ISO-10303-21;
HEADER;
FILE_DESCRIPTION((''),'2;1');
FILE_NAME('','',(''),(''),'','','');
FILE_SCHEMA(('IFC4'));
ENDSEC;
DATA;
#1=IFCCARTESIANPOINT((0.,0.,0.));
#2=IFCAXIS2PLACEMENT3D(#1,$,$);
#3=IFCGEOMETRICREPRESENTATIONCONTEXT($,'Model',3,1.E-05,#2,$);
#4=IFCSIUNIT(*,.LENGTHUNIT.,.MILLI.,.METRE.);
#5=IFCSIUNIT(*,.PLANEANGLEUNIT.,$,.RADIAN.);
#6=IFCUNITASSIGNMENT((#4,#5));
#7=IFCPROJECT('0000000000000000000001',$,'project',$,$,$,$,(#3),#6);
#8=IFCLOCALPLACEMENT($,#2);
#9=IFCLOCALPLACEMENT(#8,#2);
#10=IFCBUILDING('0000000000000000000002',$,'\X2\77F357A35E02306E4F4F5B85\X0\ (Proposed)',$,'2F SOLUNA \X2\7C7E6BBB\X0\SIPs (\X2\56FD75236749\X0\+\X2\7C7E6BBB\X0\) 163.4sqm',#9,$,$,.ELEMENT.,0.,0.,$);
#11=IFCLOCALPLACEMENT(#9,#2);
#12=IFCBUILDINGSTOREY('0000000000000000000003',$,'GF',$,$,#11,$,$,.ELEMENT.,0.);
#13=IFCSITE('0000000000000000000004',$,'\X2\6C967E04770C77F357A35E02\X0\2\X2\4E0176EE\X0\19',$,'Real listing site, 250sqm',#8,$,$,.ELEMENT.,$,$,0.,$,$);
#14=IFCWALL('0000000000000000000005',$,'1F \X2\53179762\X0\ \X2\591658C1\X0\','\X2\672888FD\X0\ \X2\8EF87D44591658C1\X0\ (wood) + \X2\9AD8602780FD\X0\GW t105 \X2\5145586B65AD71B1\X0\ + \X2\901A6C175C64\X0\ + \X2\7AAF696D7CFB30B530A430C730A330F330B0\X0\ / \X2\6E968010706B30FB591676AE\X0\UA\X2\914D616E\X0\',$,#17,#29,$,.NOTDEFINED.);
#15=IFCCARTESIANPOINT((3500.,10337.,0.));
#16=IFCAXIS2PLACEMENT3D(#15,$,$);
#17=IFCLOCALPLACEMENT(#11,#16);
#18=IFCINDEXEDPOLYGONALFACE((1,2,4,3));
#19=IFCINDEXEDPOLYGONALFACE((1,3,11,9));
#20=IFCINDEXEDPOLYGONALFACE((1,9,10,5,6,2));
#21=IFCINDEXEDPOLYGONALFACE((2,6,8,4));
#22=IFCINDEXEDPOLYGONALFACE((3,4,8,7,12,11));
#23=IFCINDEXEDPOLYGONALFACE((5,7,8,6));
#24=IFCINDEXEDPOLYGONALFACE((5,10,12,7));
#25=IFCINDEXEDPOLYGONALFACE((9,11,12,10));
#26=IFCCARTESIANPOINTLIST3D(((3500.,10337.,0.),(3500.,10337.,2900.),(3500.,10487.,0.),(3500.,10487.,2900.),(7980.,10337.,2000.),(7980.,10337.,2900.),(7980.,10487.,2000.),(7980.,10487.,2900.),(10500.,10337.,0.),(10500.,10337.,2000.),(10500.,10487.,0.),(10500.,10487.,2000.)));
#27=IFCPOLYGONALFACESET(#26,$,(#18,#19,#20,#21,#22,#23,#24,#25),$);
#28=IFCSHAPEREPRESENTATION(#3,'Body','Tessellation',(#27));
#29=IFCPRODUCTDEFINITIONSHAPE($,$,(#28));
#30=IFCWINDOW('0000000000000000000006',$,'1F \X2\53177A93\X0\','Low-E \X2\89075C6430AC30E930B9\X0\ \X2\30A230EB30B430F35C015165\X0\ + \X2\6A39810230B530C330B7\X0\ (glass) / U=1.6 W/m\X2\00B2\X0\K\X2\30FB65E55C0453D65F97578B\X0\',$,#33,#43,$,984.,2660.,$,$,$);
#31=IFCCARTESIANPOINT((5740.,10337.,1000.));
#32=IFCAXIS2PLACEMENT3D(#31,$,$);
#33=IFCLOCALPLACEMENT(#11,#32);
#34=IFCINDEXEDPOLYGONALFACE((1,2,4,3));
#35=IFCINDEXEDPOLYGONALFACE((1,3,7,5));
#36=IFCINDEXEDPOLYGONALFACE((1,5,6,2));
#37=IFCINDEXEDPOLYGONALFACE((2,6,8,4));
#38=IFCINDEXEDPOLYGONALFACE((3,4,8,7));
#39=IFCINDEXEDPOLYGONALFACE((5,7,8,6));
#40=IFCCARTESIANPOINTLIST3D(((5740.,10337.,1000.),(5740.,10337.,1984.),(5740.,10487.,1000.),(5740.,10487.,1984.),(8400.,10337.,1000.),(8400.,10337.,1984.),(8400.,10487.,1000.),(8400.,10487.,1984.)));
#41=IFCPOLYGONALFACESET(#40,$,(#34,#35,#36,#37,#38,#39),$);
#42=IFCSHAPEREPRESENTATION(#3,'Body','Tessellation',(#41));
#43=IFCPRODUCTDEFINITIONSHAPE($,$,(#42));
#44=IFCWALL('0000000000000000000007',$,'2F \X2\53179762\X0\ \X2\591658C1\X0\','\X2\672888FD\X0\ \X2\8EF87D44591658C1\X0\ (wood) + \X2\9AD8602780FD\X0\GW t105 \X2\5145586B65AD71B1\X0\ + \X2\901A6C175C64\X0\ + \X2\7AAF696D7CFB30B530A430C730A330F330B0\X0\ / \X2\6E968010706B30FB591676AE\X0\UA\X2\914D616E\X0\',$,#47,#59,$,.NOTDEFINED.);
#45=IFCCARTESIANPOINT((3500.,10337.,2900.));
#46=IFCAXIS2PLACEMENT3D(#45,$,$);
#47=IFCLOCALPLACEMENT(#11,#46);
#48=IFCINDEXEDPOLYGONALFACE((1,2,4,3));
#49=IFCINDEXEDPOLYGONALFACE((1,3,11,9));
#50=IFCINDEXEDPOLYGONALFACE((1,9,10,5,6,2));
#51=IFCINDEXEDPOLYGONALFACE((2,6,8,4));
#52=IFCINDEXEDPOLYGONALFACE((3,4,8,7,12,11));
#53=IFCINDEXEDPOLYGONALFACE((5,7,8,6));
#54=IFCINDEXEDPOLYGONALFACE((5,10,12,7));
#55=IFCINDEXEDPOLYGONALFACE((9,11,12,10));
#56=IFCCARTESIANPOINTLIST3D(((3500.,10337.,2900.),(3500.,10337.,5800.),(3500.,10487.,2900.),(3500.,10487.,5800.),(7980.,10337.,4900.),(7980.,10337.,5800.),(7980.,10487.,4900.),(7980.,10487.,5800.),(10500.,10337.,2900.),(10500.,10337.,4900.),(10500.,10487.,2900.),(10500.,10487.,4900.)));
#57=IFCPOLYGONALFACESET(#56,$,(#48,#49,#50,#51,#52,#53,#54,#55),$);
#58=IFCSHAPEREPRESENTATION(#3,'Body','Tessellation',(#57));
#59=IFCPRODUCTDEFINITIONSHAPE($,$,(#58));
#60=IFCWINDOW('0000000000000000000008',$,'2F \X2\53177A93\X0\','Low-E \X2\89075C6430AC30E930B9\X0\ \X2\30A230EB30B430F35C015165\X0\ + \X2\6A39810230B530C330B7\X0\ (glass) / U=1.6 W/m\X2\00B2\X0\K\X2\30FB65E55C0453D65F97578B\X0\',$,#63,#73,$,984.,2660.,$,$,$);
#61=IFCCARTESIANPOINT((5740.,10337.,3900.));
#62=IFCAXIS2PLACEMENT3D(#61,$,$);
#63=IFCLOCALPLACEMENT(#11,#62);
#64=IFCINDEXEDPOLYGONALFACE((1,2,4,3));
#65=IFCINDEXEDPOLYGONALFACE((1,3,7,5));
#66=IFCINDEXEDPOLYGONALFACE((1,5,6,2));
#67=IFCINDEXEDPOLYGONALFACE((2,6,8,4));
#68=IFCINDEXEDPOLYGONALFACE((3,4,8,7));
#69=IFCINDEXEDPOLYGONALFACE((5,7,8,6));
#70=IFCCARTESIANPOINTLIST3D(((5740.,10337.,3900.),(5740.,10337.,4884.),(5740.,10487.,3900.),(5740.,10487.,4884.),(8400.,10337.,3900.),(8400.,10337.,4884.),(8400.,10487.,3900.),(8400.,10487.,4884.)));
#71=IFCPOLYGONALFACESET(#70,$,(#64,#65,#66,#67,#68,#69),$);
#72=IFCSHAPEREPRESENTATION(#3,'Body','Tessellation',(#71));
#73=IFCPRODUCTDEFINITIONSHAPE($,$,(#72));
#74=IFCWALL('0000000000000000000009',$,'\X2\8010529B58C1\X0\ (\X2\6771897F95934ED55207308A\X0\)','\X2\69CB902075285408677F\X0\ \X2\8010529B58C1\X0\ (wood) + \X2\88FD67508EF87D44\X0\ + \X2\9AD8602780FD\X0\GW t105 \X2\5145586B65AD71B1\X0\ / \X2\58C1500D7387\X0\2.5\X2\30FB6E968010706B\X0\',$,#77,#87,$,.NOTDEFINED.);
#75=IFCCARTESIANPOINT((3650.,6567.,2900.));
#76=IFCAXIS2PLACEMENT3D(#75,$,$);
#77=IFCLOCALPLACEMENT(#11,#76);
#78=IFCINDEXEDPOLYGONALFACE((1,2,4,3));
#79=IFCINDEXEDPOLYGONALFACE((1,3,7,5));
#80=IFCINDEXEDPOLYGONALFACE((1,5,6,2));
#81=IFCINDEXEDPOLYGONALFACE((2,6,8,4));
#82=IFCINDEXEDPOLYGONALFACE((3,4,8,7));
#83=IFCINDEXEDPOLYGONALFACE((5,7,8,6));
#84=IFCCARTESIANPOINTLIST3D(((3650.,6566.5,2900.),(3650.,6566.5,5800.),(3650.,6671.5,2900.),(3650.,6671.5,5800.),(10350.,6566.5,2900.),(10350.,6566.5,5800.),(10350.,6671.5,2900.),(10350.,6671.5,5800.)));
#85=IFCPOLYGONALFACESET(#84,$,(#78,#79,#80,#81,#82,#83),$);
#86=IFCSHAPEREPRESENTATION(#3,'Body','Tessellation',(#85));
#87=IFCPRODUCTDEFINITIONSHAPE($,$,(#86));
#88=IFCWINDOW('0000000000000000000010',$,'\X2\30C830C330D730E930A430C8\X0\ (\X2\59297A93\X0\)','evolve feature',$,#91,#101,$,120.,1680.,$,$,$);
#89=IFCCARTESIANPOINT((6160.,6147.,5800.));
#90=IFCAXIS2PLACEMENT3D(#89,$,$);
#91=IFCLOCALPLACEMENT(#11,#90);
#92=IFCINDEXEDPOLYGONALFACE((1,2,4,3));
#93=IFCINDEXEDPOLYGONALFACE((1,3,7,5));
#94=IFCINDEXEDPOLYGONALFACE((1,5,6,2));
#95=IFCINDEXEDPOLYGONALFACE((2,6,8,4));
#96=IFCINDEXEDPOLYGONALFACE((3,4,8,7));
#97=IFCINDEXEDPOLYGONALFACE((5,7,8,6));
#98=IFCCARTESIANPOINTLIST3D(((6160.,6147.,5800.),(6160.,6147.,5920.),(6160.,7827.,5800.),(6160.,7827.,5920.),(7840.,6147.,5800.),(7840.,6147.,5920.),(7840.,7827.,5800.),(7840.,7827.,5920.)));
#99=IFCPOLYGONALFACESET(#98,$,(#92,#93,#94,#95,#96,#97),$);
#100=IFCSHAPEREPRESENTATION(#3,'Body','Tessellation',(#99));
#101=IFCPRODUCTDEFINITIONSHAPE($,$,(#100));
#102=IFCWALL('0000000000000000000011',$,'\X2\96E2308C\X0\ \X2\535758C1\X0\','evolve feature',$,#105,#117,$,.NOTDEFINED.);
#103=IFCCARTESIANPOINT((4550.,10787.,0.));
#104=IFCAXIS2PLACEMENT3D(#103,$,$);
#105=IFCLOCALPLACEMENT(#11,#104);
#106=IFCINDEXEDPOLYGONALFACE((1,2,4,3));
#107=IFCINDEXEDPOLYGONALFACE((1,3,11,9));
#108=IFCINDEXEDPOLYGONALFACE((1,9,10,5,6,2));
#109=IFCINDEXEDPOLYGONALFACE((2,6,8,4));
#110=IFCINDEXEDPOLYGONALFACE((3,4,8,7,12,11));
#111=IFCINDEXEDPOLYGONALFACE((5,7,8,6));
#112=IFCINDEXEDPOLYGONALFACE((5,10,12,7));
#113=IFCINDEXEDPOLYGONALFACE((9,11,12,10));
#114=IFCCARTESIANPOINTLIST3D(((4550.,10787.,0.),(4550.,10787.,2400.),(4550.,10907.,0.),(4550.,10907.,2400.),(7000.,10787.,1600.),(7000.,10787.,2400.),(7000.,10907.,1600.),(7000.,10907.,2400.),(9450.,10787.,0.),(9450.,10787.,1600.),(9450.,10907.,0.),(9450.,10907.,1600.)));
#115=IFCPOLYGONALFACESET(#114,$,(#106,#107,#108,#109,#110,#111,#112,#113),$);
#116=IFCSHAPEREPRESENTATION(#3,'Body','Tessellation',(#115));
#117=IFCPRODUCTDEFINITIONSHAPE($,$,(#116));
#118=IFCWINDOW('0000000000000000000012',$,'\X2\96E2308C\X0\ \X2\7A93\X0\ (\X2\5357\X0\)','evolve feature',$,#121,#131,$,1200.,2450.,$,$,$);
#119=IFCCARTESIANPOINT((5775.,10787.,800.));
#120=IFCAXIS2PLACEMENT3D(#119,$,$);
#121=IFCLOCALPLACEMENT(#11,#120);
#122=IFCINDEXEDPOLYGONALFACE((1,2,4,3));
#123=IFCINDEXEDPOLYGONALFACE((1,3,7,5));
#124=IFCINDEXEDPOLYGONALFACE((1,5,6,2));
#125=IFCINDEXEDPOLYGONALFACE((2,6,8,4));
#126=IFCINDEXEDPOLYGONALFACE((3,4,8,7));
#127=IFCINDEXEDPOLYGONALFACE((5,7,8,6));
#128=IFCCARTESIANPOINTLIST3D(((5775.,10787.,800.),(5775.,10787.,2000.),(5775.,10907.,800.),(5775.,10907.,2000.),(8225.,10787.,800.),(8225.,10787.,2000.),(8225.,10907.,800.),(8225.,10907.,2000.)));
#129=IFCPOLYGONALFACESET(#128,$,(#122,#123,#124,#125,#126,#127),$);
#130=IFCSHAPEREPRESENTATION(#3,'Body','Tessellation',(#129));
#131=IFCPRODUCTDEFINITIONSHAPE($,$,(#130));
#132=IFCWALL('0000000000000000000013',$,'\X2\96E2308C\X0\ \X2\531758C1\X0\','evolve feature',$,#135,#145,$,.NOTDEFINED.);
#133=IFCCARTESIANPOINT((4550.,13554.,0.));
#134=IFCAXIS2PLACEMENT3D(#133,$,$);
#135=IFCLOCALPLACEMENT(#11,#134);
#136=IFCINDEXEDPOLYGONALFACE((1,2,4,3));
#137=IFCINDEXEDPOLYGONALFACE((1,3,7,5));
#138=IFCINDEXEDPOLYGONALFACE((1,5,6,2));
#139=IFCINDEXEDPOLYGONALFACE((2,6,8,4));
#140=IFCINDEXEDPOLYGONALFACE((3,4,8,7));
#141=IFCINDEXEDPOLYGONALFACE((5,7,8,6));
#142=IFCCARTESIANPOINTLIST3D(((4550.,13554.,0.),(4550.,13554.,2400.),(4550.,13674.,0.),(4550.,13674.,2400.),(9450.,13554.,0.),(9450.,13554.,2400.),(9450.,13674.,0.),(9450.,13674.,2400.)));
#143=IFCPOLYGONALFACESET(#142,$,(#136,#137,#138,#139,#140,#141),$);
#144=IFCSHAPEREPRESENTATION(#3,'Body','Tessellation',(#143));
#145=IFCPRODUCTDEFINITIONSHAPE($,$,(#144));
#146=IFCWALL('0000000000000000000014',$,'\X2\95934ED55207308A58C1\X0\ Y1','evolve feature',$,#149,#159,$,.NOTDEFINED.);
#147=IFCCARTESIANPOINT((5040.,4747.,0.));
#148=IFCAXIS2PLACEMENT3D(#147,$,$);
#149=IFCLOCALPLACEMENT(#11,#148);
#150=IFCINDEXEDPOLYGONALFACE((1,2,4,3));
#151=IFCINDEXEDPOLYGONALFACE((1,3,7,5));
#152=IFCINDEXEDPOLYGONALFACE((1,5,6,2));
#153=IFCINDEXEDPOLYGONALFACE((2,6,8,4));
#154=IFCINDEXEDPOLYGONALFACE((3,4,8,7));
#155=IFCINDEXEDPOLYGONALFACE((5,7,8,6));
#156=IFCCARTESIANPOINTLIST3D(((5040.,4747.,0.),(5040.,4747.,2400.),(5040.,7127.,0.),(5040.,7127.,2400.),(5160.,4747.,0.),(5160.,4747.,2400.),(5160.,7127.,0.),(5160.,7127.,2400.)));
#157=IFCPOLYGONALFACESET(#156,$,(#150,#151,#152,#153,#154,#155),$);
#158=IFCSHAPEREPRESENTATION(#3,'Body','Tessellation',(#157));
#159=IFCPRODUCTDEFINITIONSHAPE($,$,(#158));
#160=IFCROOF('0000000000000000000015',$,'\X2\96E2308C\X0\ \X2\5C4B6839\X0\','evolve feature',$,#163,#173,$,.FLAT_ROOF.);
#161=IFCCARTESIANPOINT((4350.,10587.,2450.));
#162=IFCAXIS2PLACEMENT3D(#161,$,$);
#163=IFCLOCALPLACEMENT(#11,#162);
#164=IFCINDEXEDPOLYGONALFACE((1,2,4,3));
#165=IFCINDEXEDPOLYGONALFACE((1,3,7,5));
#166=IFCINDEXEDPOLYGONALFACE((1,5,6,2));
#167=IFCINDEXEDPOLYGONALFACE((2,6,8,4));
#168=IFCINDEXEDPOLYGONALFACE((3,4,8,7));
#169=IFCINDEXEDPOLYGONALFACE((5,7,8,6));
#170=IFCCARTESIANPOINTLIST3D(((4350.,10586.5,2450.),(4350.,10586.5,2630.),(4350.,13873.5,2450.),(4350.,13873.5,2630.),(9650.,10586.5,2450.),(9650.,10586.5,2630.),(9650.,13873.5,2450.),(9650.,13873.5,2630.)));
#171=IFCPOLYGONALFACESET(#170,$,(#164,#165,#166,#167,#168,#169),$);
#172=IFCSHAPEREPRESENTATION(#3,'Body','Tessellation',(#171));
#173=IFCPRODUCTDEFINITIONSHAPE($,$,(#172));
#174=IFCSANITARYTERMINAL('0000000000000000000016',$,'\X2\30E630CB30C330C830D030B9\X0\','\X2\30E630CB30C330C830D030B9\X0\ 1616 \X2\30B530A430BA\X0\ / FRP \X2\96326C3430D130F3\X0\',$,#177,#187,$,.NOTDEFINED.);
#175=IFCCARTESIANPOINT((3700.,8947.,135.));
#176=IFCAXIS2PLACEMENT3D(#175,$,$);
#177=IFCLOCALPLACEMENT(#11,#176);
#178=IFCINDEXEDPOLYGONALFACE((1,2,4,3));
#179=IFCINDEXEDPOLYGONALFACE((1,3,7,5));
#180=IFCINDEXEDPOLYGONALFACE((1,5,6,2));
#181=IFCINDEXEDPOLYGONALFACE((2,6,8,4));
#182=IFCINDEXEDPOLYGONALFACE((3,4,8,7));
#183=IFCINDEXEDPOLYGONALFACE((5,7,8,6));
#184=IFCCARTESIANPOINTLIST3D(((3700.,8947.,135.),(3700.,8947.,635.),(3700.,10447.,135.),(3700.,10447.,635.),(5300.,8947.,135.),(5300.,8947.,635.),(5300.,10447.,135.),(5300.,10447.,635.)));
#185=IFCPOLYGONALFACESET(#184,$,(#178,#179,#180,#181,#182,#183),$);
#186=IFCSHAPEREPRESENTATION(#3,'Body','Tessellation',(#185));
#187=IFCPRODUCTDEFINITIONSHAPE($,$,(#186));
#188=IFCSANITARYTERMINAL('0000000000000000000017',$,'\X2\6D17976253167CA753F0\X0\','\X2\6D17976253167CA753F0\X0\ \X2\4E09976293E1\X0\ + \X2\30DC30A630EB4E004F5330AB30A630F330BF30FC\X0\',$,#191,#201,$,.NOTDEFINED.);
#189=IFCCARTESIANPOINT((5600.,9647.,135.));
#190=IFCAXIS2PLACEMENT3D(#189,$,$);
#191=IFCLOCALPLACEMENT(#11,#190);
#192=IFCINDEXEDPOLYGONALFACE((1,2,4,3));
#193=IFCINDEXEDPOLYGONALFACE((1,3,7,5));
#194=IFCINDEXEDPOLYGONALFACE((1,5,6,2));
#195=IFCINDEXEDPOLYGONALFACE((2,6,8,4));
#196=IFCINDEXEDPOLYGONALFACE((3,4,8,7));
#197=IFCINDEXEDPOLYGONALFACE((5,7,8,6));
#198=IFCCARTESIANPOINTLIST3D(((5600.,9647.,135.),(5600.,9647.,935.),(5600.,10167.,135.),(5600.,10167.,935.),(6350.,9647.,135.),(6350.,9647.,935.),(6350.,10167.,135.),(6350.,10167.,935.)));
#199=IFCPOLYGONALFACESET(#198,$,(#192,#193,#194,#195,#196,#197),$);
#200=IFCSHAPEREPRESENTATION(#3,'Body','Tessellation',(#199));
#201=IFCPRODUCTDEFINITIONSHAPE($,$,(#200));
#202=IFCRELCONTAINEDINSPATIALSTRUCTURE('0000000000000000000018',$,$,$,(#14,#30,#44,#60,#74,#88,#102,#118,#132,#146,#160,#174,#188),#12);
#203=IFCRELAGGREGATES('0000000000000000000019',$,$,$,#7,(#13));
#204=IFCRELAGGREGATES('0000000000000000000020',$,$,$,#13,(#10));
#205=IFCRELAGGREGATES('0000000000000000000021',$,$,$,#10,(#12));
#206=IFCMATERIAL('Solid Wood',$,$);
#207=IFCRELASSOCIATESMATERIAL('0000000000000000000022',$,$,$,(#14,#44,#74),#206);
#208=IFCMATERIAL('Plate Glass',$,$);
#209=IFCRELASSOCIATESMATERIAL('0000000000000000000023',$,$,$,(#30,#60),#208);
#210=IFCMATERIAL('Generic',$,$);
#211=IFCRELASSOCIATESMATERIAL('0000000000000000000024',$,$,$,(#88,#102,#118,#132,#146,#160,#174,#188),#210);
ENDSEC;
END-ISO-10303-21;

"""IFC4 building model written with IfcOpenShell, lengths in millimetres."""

from ifc_helpers import new_model, si_unit, frame, frame_2d, origin, place, context, project, spatial, rectangle, extrude, material, element, fill, save


model = new_model("IFC4")

# Units and contexts
model_context = context("Model", 3, precision=1e-05, world=origin())
ifc_project = project(units=[si_unit("LENGTHUNIT", "METRE", prefix="MILLI"), si_unit("PLANEANGLEUNIT", "RADIAN")], contexts=[model_context])

# Site, building, storey
site_placement = place(None, origin())
site = spatial("IfcSite", under=ifc_project, at=site_placement, Name="沖縄県石垣市2丁目19", ObjectType="Real listing site, 250sqm", CompositionType="ELEMENT", RefElevation=0.0)
building_placement = place(site_placement, origin())
building = spatial("IfcBuilding", under=site, at=building_placement, Name="石垣市の住宅 (Proposed)", ObjectType="2F SOLUNA 籾殻SIPs (国産杉+籾殻) 163.4sqm", CompositionType="ELEMENT", ElevationOfRefHeight=0.0, ElevationOfTerrain=0.0)
storey_placement = place(building_placement, origin())
storey = spatial("IfcBuildingStorey", under=building, at=storey_placement, Name="GF", CompositionType="ELEMENT", Elevation=0.0)

# Shared definitions
ifc_material_1 = material(Name="Generic")

# Wall, opening, window
ifc_material_2 = material(Name="Solid Wood")
wall_1_placement = place(storey_placement, frame((3500.0, 10337.0, 0.0)))
wall_1 = element("IfcWall", 1, at=wall_1_placement, inside=storey, material=ifc_material_2, Name="1F 北面 外壁", Description="木製 軸組外壁 (wood) + 高性能GW t105 充填断熱 + 通気層 + 窯業系サイディング / 準耐火・外皮UA配慮", PredefinedType="NOTDEFINED", context=model_context, shape_type="SweptSolid", body=[
    extrude(rectangle(XDim=7000.0, YDim=150.0, at=frame_2d((3500.0, 75.0))), frame((3500.0, 10337.0, 0.0)), (0.0, 0.0, 1.0), 2900.0),
])
opening_1_placement = place(storey_placement, frame((5740.0, 10337.0, 1000.0)))
opening_1 = element("IfcOpeningElement", 2, at=opening_1_placement, cuts=wall_1, PredefinedType="NOTDEFINED", context=model_context, shape_type="SweptSolid", body=[
    extrude(rectangle(XDim=2660.0, YDim=150.0, at=frame_2d((1330.0, 75.0))), frame((5740.0, 10337.0, 1000.0)), (0.0, 0.0, 1.0), 984.0),
])
ifc_material_3 = material(Name="Plate Glass")
window_1_placement = place(storey_placement, frame((5740.0, 10337.0, 1000.0)))
window_1 = element("IfcWindow", 3, at=window_1_placement, inside=storey, material=ifc_material_3, Name="1F 北窓", Description="Low-E 複層ガラス アルゴン封入 + 樹脂サッシ (glass) / U=1.6 W/m²K・日射取得型", OverallHeight=984.0, OverallWidth=2660.0, context=model_context, shape_type="SweptSolid", body=[
    extrude(rectangle(XDim=2660.0, YDim=150.0, at=frame_2d((1330.0, 75.0))), frame((5740.0, 10337.0, 1000.0)), (0.0, 0.0, 1.0), 984.0),
])
fill(opening_1, window_1)

# Wall, opening, window
wall_2_placement = place(storey_placement, frame((3500.0, 10337.0, 2900.0)))
wall_2 = element("IfcWall", 4, at=wall_2_placement, inside=storey, material=ifc_material_2, Name="2F 北面 外壁", Description="木製 軸組外壁 (wood) + 高性能GW t105 充填断熱 + 通気層 + 窯業系サイディング / 準耐火・外皮UA配慮", PredefinedType="NOTDEFINED", context=model_context, shape_type="SweptSolid", body=[
    extrude(rectangle(XDim=7000.0, YDim=150.0, at=frame_2d((3500.0, 75.0))), frame((3500.0, 10337.0, 2900.0)), (0.0, 0.0, 1.0), 2900.0),
])
opening_2_placement = place(storey_placement, frame((5740.0, 10337.0, 3900.0)))
opening_2 = element("IfcOpeningElement", 5, at=opening_2_placement, cuts=wall_2, PredefinedType="NOTDEFINED", context=model_context, shape_type="SweptSolid", body=[
    extrude(rectangle(XDim=2660.0, YDim=150.0, at=frame_2d((1330.0, 75.0))), frame((5740.0, 10337.0, 3900.0)), (0.0, 0.0, 1.0), 984.0),
])
window_2_placement = place(storey_placement, frame((5740.0, 10337.0, 3900.0)))
window_2 = element("IfcWindow", 6, at=window_2_placement, inside=storey, material=ifc_material_3, Name="2F 北窓", Description="Low-E 複層ガラス アルゴン封入 + 樹脂サッシ (glass) / U=1.6 W/m²K・日射取得型", OverallHeight=984.0, OverallWidth=2660.0, context=model_context, shape_type="SweptSolid", body=[
    extrude(rectangle(XDim=2660.0, YDim=150.0, at=frame_2d((1330.0, 75.0))), frame((5740.0, 10337.0, 3900.0)), (0.0, 0.0, 1.0), 984.0),
])
fill(opening_2, window_2)

# Wall
wall_3_placement = place(storey_placement, frame((3650.0, 6567.0, 2900.0)))
element("IfcWall", 7, at=wall_3_placement, inside=storey, material=ifc_material_2, Name="耐力壁 (東西間仕切り)", Description="構造用合板 耐力壁 (wood) + 製材軸組 + 高性能GW t105 充填断熱 / 壁倍率2.5・準耐火", PredefinedType="NOTDEFINED", context=model_context, shape_type="SweptSolid", body=[
    extrude(rectangle(XDim=6700.0, YDim=105.0, at=frame_2d((3350.0, 52.0))), frame((3650.0, 6567.0, 2900.0)), (0.0, 0.0, 1.0), 2900.0),
])

# Window
window_3_placement = place(storey_placement, frame((6160.0, 6147.0, 5800.0)))
element("IfcWindow", 8, at=window_3_placement, inside=storey, material=ifc_material_1, Name="トップライト (天窓)", Description="evolve feature", OverallHeight=120.0, OverallWidth=1680.0, context=model_context, shape_type="SweptSolid", body=[
    extrude(rectangle(XDim=1680.0, YDim=1680.0, at=frame_2d((840.0, 840.0))), frame((6160.0, 6147.0, 5800.0)), (0.0, 0.0, 1.0), 120.0),
])

# Wall, opening, window
wall_4_placement = place(storey_placement, frame((4550.0, 10787.0, 0.0)))
wall_4 = element("IfcWall", 9, at=wall_4_placement, inside=storey, material=ifc_material_1, Name="離れ 南壁", Description="evolve feature", PredefinedType="NOTDEFINED", context=model_context, shape_type="SweptSolid", body=[
    extrude(rectangle(XDim=4900.0, YDim=120.0, at=frame_2d((2450.0, 60.0))), frame((4550.0, 10787.0, 0.0)), (0.0, 0.0, 1.0), 2400.0),
])
opening_3_placement = place(storey_placement, frame((5775.0, 10787.0, 800.0)))
opening_3 = element("IfcOpeningElement", 10, at=opening_3_placement, cuts=wall_4, PredefinedType="NOTDEFINED", context=model_context, shape_type="SweptSolid", body=[
    extrude(rectangle(XDim=2450.0, YDim=120.0, at=frame_2d((1225.0, 60.0))), frame((5775.0, 10787.0, 800.0)), (0.0, 0.0, 1.0), 1200.0),
])
window_4_placement = place(storey_placement, frame((5775.0, 10787.0, 800.0)))
window_4 = element("IfcWindow", 11, at=window_4_placement, inside=storey, material=ifc_material_1, Name="離れ 窓 (南)", Description="evolve feature", OverallHeight=1200.0, OverallWidth=2450.0, context=model_context, shape_type="SweptSolid", body=[
    extrude(rectangle(XDim=2450.0, YDim=120.0, at=frame_2d((1225.0, 60.0))), frame((5775.0, 10787.0, 800.0)), (0.0, 0.0, 1.0), 1200.0),
])
fill(opening_3, window_4)

# Walls
wall_5_placement = place(storey_placement, frame((4550.0, 13554.0, 0.0)))
element("IfcWall", 12, at=wall_5_placement, inside=storey, material=ifc_material_1, Name="離れ 北壁", Description="evolve feature", PredefinedType="NOTDEFINED", context=model_context, shape_type="SweptSolid", body=[
    extrude(rectangle(XDim=4900.0, YDim=120.0, at=frame_2d((2450.0, 60.0))), frame((4550.0, 13554.0, 0.0)), (0.0, 0.0, 1.0), 2400.0),
])
wall_6_placement = place(storey_placement, frame((5040.0, 4747.0, 0.0)))
element("IfcWall", 13, at=wall_6_placement, inside=storey, material=ifc_material_1, Name="間仕切り壁 Y1", Description="evolve feature", PredefinedType="NOTDEFINED", context=model_context, shape_type="SweptSolid", body=[
    extrude(rectangle(XDim=120.0, YDim=2380.0, at=frame_2d((60.0, 1190.0))), frame((5040.0, 4747.0, 0.0)), (0.0, 0.0, 1.0), 2400.0),
])

# Roof
roof_placement = place(storey_placement, frame((4350.0, 10587.0, 2450.0)))
element("IfcRoof", 14, at=roof_placement, inside=storey, material=ifc_material_1, Name="離れ 屋根", Description="evolve feature", PredefinedType="FLAT_ROOF", context=model_context, shape_type="SweptSolid", body=[
    extrude(rectangle(XDim=5300.0, YDim=3287.0, at=frame_2d((2650.0, 1643.0))), frame((4350.0, 10587.0, 2450.0)), (0.0, 0.0, 1.0), 180.0),
])

# Sanitary terminals
sanitary_terminal_1_placement = place(storey_placement, frame((3700.0, 8947.0, 135.0)))
element("IfcSanitaryTerminal", 15, at=sanitary_terminal_1_placement, inside=storey, material=ifc_material_1, Name="ユニットバス", Description="ユニットバス 1616 サイズ / FRP 防水パン", PredefinedType="NOTDEFINED", context=model_context, shape_type="SweptSolid", body=[
    extrude(rectangle(XDim=1600.0, YDim=1500.0, at=frame_2d((800.0, 750.0))), frame((3700.0, 8947.0, 135.0)), (0.0, 0.0, 1.0), 500.0),
])
sanitary_terminal_2_placement = place(storey_placement, frame((5600.0, 9647.0, 135.0)))
element("IfcSanitaryTerminal", 16, at=sanitary_terminal_2_placement, inside=storey, material=ifc_material_1, Name="洗面化粧台", Description="洗面化粧台 三面鏡 + ボウル一体カウンター", PredefinedType="NOTDEFINED", context=model_context, shape_type="SweptSolid", body=[
    extrude(rectangle(XDim=750.0, YDim=520.0, at=frame_2d((375.0, 260.0))), frame((5600.0, 9647.0, 135.0)), (0.0, 0.0, 1.0), 800.0),
])

save(model, "model.ifc")
